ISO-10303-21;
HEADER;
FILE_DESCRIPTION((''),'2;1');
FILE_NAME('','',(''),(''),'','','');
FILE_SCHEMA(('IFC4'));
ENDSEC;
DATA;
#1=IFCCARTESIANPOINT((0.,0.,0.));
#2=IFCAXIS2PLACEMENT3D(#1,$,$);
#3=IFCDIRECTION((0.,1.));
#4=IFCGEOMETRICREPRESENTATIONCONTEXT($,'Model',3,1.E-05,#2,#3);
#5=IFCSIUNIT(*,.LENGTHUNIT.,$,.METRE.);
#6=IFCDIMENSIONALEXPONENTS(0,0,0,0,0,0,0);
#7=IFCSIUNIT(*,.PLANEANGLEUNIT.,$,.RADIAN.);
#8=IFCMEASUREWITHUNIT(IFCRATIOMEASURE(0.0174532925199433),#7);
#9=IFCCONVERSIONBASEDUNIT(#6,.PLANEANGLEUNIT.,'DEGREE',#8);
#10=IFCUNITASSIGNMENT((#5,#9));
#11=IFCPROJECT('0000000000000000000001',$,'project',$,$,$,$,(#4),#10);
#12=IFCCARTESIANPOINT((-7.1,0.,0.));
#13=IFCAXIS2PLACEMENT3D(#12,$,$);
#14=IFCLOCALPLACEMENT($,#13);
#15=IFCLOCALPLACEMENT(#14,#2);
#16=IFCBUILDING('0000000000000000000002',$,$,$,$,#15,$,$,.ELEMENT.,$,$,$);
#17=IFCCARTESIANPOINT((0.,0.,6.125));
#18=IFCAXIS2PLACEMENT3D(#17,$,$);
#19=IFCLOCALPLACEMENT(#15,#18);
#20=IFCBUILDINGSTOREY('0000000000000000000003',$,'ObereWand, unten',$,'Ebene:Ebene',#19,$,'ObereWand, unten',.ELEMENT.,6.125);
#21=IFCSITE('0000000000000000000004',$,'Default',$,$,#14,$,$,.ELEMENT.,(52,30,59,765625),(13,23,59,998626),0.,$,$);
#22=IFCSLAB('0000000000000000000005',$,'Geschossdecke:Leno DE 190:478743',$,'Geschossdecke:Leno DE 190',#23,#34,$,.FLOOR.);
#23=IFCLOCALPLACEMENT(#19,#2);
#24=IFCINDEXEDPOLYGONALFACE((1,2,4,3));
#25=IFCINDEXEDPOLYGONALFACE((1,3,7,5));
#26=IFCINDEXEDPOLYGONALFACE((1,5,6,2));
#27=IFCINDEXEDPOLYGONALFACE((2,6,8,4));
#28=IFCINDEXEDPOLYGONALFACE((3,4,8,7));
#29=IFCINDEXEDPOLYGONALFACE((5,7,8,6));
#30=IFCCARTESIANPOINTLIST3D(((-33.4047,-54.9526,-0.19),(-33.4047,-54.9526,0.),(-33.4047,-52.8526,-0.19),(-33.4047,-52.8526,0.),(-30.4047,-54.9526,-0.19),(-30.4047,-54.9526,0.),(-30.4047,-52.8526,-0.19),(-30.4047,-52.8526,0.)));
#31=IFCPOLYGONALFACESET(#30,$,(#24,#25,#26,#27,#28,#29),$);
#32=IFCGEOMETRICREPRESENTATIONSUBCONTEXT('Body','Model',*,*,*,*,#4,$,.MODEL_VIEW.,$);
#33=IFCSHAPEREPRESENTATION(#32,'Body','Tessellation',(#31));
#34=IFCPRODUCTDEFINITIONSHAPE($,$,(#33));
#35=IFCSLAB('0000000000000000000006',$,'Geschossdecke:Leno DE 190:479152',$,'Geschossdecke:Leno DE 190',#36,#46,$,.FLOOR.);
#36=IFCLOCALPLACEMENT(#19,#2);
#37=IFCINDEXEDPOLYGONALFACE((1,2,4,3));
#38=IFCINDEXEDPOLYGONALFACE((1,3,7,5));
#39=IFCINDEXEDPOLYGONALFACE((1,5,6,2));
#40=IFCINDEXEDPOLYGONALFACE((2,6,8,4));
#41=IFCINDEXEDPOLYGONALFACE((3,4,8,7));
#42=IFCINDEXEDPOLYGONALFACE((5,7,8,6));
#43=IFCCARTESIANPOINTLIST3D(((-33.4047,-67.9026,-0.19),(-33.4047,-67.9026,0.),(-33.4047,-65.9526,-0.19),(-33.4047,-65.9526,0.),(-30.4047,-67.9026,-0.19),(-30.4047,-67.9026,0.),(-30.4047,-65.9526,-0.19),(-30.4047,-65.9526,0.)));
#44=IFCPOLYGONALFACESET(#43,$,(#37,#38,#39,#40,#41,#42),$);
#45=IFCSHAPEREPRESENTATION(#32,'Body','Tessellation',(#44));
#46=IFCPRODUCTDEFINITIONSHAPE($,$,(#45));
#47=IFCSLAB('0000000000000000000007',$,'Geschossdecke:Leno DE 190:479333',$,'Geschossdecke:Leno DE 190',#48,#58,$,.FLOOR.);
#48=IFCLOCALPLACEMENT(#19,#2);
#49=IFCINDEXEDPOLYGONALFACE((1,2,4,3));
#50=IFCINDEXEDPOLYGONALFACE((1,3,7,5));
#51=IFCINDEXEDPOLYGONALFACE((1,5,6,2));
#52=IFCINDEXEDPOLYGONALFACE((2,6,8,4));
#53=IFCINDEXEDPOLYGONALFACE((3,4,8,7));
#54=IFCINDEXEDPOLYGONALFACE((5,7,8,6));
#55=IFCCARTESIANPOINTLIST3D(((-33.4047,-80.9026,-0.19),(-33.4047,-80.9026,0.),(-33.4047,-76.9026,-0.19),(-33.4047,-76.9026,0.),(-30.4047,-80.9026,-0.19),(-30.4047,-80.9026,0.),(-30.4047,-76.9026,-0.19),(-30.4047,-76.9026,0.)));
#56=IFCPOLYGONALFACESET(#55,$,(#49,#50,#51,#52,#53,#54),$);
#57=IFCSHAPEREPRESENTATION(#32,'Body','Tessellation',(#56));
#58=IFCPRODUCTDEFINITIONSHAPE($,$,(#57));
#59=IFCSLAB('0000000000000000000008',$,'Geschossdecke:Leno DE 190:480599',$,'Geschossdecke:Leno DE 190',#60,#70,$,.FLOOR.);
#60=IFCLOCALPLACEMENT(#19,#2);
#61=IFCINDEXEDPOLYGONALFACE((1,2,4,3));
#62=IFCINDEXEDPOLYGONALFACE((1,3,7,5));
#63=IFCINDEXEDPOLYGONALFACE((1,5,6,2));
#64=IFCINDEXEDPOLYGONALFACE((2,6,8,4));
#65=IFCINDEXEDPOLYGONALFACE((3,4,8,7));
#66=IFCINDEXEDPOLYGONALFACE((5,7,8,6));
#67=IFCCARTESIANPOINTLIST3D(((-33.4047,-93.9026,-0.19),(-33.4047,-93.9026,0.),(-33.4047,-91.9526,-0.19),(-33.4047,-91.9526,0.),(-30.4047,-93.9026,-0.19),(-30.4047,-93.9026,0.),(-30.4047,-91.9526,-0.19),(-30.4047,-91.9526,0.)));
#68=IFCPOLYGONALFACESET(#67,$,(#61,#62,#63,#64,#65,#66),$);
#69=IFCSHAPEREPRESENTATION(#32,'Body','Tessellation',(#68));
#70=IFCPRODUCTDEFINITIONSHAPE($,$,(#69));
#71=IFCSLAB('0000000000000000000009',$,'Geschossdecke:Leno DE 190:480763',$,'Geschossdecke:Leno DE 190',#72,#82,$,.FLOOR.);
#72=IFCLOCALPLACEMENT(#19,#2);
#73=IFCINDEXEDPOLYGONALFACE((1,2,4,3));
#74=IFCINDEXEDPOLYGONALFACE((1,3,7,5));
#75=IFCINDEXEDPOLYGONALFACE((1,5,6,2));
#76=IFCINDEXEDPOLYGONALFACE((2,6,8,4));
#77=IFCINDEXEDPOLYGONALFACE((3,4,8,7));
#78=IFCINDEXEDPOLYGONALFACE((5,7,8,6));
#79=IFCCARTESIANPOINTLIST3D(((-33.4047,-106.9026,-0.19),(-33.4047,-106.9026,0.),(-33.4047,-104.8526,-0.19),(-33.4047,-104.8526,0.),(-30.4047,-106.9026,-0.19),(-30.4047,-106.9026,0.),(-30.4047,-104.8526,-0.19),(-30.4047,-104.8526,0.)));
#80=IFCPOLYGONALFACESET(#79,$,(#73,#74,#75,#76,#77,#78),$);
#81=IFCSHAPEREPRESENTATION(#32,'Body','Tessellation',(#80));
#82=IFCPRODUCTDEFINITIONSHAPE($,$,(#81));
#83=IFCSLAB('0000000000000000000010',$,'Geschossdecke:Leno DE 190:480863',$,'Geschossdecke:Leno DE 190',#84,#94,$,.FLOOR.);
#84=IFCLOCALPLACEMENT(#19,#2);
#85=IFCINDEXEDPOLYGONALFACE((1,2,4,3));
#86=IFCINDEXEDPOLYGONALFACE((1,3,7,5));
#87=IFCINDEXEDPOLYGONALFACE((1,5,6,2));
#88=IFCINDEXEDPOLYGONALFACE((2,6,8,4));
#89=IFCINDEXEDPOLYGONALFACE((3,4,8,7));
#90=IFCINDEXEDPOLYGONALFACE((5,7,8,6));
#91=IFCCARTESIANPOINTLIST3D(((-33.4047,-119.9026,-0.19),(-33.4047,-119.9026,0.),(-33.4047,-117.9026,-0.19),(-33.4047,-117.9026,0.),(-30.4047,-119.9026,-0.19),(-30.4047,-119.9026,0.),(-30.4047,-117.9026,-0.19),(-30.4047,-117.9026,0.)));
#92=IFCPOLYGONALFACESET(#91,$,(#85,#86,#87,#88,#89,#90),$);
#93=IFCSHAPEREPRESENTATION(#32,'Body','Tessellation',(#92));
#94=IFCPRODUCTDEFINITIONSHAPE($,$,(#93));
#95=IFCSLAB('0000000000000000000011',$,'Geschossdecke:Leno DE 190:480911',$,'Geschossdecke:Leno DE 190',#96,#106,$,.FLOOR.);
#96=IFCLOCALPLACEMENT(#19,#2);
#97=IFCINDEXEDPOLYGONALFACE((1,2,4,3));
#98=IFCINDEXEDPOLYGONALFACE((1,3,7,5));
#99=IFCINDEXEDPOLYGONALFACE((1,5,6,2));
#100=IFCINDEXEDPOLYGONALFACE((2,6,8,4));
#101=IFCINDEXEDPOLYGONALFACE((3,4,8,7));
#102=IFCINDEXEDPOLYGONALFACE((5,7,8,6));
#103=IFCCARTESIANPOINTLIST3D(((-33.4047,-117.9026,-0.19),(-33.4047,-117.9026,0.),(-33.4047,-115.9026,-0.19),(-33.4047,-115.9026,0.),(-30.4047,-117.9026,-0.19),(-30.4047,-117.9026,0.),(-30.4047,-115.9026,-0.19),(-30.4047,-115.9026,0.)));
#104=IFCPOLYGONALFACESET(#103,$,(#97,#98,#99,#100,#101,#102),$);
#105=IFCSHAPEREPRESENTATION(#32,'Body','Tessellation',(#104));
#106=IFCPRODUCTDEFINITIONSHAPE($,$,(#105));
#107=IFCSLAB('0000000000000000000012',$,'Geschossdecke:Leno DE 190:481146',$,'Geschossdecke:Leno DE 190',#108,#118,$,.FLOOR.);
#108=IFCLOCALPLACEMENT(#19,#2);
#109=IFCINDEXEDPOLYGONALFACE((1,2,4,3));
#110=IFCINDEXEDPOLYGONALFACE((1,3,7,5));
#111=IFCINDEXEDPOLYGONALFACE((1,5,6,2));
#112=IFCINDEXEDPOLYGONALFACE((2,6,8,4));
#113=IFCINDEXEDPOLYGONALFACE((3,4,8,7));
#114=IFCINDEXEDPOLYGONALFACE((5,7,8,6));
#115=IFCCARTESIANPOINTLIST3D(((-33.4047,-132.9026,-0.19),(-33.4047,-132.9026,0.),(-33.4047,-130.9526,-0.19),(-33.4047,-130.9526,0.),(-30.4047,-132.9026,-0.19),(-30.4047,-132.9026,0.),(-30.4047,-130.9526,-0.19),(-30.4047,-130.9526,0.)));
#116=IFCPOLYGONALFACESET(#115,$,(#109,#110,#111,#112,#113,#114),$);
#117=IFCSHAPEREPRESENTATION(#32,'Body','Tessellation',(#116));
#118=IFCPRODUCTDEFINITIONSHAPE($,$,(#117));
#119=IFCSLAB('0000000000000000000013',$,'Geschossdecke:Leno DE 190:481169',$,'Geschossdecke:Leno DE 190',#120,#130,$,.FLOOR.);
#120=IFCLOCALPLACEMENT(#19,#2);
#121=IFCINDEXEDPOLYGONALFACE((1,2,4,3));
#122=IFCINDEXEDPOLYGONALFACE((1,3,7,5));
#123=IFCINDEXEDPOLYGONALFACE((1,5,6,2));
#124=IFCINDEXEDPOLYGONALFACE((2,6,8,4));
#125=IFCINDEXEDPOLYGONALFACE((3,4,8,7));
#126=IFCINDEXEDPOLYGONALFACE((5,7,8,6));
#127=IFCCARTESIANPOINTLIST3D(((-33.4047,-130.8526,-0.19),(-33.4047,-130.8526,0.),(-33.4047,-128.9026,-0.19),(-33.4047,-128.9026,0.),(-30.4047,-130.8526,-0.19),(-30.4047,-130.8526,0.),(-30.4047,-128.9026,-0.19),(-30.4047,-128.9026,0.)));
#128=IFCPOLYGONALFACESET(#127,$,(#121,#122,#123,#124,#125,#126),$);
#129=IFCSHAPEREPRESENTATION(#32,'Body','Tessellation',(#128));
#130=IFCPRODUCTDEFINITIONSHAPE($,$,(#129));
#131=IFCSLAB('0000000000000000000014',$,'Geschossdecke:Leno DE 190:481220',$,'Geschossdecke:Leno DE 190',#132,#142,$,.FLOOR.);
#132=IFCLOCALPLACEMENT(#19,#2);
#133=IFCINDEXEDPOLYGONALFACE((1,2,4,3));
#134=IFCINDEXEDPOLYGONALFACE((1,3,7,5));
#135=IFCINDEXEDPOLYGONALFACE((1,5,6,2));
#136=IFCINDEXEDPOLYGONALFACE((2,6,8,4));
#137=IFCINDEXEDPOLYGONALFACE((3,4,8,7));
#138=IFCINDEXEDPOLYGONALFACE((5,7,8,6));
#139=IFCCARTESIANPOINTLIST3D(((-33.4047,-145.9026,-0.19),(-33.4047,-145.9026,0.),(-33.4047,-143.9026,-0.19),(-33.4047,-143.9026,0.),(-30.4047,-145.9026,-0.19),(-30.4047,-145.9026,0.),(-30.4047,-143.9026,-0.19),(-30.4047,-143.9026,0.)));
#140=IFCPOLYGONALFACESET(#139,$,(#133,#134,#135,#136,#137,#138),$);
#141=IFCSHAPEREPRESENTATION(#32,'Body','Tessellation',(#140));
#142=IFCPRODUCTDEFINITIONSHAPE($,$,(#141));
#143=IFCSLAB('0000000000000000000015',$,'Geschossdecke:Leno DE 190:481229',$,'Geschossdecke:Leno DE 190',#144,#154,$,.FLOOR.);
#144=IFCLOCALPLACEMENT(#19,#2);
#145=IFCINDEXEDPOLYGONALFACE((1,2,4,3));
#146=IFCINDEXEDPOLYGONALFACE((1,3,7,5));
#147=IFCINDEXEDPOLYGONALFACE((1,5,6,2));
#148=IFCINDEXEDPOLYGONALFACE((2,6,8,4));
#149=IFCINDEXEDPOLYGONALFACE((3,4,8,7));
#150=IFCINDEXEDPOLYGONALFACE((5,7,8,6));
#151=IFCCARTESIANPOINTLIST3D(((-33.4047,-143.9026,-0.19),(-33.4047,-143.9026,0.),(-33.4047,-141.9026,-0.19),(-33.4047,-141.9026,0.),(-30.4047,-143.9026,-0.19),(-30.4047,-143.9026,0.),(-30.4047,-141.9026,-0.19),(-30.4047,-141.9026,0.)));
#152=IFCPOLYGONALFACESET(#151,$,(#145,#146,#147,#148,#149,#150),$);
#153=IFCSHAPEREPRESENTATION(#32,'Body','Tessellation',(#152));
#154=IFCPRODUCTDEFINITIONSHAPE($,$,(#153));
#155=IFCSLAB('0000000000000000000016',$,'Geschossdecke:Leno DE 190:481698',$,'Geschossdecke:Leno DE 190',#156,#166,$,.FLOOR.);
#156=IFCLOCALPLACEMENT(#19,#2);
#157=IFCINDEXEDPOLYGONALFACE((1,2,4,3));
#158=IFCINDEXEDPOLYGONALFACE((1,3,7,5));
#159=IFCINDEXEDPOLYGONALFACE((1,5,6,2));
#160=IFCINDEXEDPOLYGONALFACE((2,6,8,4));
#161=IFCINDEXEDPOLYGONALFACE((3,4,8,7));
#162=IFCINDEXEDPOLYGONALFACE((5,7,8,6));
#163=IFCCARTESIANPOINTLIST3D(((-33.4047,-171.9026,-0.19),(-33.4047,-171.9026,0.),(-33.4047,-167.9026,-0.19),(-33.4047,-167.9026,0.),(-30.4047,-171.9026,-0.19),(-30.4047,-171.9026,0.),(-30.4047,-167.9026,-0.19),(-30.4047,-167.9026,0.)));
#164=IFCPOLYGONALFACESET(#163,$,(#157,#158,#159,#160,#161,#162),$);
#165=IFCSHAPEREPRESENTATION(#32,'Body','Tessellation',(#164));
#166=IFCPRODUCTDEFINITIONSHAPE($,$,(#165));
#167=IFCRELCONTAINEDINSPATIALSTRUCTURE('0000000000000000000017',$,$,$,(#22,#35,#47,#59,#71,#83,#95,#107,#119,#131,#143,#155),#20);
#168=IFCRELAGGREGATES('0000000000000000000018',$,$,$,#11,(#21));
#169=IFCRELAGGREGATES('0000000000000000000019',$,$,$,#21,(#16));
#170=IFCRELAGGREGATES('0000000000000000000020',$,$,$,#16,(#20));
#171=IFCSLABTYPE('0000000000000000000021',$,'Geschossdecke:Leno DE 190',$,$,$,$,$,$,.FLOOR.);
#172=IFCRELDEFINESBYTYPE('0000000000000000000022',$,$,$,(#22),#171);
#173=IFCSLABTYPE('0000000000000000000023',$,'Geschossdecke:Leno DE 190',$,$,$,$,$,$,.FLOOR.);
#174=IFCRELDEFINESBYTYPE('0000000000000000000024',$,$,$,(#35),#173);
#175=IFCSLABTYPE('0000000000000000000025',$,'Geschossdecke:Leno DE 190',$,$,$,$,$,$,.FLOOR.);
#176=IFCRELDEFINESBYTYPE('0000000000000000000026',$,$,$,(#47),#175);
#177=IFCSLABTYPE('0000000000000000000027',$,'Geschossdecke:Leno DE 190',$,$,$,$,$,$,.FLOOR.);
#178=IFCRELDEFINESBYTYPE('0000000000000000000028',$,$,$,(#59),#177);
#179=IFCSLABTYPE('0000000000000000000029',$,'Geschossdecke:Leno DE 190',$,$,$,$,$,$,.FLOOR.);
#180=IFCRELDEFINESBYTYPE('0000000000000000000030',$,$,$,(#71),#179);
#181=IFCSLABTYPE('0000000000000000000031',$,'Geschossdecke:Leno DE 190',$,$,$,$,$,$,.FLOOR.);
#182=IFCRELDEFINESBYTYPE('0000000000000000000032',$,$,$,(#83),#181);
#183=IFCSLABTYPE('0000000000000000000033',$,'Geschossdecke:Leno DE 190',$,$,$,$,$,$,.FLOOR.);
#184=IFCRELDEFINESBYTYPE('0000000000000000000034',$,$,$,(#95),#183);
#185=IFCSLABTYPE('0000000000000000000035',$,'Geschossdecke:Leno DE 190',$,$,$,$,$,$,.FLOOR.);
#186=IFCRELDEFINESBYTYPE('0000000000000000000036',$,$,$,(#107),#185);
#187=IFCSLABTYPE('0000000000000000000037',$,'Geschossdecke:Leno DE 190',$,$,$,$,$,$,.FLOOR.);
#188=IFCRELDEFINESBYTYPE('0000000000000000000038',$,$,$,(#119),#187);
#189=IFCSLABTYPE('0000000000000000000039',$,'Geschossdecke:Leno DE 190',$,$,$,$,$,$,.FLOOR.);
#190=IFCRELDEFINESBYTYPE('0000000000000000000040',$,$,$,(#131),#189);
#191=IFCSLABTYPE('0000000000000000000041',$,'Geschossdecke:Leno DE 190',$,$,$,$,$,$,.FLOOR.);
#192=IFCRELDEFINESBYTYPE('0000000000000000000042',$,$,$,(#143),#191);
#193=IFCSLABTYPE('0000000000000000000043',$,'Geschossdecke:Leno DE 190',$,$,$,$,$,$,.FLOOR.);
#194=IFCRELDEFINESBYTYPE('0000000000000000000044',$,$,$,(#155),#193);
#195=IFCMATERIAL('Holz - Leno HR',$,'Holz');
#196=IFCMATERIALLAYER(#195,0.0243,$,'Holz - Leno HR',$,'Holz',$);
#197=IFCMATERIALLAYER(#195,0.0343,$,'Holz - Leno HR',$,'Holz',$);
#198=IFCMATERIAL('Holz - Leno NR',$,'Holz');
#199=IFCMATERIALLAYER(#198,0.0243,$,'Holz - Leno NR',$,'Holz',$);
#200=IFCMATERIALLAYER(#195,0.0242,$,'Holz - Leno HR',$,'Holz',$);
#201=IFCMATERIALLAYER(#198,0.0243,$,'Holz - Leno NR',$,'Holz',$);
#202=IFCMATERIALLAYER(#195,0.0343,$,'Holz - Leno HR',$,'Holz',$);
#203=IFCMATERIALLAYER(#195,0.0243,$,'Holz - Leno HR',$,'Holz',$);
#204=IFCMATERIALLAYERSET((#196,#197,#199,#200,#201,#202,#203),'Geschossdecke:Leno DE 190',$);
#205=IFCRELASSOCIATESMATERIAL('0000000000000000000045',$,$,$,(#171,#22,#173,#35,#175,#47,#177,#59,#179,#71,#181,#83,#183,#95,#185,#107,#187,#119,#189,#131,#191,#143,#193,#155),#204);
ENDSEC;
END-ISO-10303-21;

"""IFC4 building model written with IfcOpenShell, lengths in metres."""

from ifc_helpers import new_model, entity, si_unit, converted_unit, direction, frame, origin, place, context, subcontext, project, spatial, indexed_curve, outline, extrude, material, layer, layer_set, type_object, element, save


model = new_model("IFC4")

# Units and contexts
model_context = context("Model", 3, precision=1e-05, world=origin(), true_north=direction((0.0, 1.0)))
body_context = subcontext(model_context, "Body", "Model", "MODEL_VIEW")
ifc_project = project(units=[si_unit("LENGTHUNIT", "METRE"), converted_unit("PLANEANGLEUNIT", "DEGREE", entity("IfcRatioMeasure", 0.0174532925199433), si_unit("PLANEANGLEUNIT", "RADIAN"), dimensions=[0, 0, 0, 0, 0, 0, 0])], contexts=[model_context])

# Site, building, storey
site_placement = place(None, frame((-7.1, 0.0, 0.0)))
site = spatial("IfcSite", under=ifc_project, at=site_placement, Name="Default", CompositionType="ELEMENT", RefLatitude=(52, 30, 59, 765625), RefLongitude=(13, 23, 59, 998626), RefElevation=0.0)
building_placement = place(site_placement, origin())
building = spatial("IfcBuilding", under=site, at=building_placement, CompositionType="ELEMENT")
storey_placement = place(building_placement, frame((0.0, 0.0, 6.125)))
storey = spatial("IfcBuildingStorey", under=building, at=storey_placement, Name="ObereWand, unten", ObjectType="Ebene:Ebene", LongName="ObereWand, unten", CompositionType="ELEMENT", Elevation=6.125)

# Slabs
ifc_material_1 = material(Name="Holz - Leno HR", Category="Holz")
ifc_layer_1 = layer(ifc_material_1, 0.0243, Name="Holz - Leno HR", Category="Holz")
ifc_layer_2 = layer(ifc_material_1, 0.0343, Name="Holz - Leno HR", Category="Holz")
ifc_material_2 = material(Name="Holz - Leno NR", Category="Holz")
ifc_layer_3 = layer(ifc_material_2, 0.0243, Name="Holz - Leno NR", Category="Holz")
ifc_layer_4 = layer(ifc_material_1, 0.0242, Name="Holz - Leno HR", Category="Holz")
ifc_layer_5 = layer(ifc_material_2, 0.0243, Name="Holz - Leno NR", Category="Holz")
ifc_layer_6 = layer(ifc_material_1, 0.0343, Name="Holz - Leno HR", Category="Holz")
ifc_layer_7 = layer(ifc_material_1, 0.0243, Name="Holz - Leno HR", Category="Holz")
ifc_layer_set_1 = layer_set([ifc_layer_1, ifc_layer_2, ifc_layer_3, ifc_layer_4, ifc_layer_5, ifc_layer_6, ifc_layer_7], Name="Geschossdecke:Leno DE 190")
slab_type_1 = type_object("IfcSlabType", Name="Geschossdecke:Leno DE 190", PredefinedType="FLOOR", material=ifc_layer_set_1)
slab_1_placement = place(storey_placement, origin())
element("IfcSlab", 1, at=slab_1_placement, inside=storey, type_object=slab_type_1, material=ifc_layer_set_1, Name="Geschossdecke:Leno DE 190:478743", ObjectType="Geschossdecke:Leno DE 190", PredefinedType="FLOOR", context=body_context, shape_type="SweptSolid", body=[
    extrude(outline(indexed_curve([(-1.05, -1.5), (1.05, -1.5), (1.05, 1.5), (-1.05, 1.5), (-1.05, -1.5)], self_intersect=False)), frame((-31.9047, -53.9026, 0.0), z_axis=(0.0, 0.0, -1.0), x_axis=(0.0, 1.0, 0.0)), (0.0, 0.0, 1.0), 0.19),
])
slab_type_2 = type_object("IfcSlabType", Name="Geschossdecke:Leno DE 190", PredefinedType="FLOOR", material=ifc_layer_set_1)
slab_2_placement = place(storey_placement, origin())
element("IfcSlab", 2, at=slab_2_placement, inside=storey, type_object=slab_type_2, material=ifc_layer_set_1, Name="Geschossdecke:Leno DE 190:479152", ObjectType="Geschossdecke:Leno DE 190", PredefinedType="FLOOR", context=body_context, shape_type="SweptSolid", body=[
    extrude(outline(indexed_curve([(-0.975, -1.5), (0.975, -1.5), (0.975, 1.5), (-0.975, 1.5), (-0.975, -1.5)], self_intersect=False)), frame((-31.9047, -66.9276, 0.0), z_axis=(0.0, 0.0, -1.0), x_axis=(0.0, 1.0, 0.0)), (0.0, 0.0, 1.0), 0.19),
])
slab_type_3 = type_object("IfcSlabType", Name="Geschossdecke:Leno DE 190", PredefinedType="FLOOR", material=ifc_layer_set_1)
slab_3_placement = place(storey_placement, origin())
element("IfcSlab", 3, at=slab_3_placement, inside=storey, type_object=slab_type_3, material=ifc_layer_set_1, Name="Geschossdecke:Leno DE 190:479333", ObjectType="Geschossdecke:Leno DE 190", PredefinedType="FLOOR", context=body_context, shape_type="SweptSolid", body=[
    extrude(outline(indexed_curve([(-2.0, -1.5), (2.0, -1.5), (2.0, 1.5), (-2.0, 1.5), (-2.0, -1.5)], self_intersect=False)), frame((-31.9047, -78.9026, 0.0), z_axis=(0.0, 0.0, -1.0), x_axis=(0.0, 1.0, 0.0)), (0.0, 0.0, 1.0), 0.19),
])
slab_type_4 = type_object("IfcSlabType", Name="Geschossdecke:Leno DE 190", PredefinedType="FLOOR", material=ifc_layer_set_1)
slab_4_placement = place(storey_placement, origin())
element("IfcSlab", 4, at=slab_4_placement, inside=storey, type_object=slab_type_4, material=ifc_layer_set_1, Name="Geschossdecke:Leno DE 190:480599", ObjectType="Geschossdecke:Leno DE 190", PredefinedType="FLOOR", context=body_context, shape_type="SweptSolid", body=[
    extrude(outline(indexed_curve([(-0.975, -1.5), (0.975, -1.5), (0.975, 1.5), (-0.975, 1.5), (-0.975, -1.5)], self_intersect=False)), frame((-31.9047, -92.9276, 0.0), z_axis=(0.0, 0.0, -1.0), x_axis=(0.0, 1.0, 0.0)), (0.0, 0.0, 1.0), 0.19),
])
slab_type_5 = type_object("IfcSlabType", Name="Geschossdecke:Leno DE 190", PredefinedType="FLOOR", material=ifc_layer_set_1)
slab_5_placement = place(storey_placement, origin())
element("IfcSlab", 5, at=slab_5_placement, inside=storey, type_object=slab_type_5, material=ifc_layer_set_1, Name="Geschossdecke:Leno DE 190:480763", ObjectType="Geschossdecke:Leno DE 190", PredefinedType="FLOOR", context=body_context, shape_type="SweptSolid", body=[
    extrude(outline(indexed_curve([(-1.025, -1.5), (1.025, -1.5), (1.025, 1.5), (-1.025, 1.5), (-1.025, -1.5)], self_intersect=False)), frame((-31.9047, -105.8776, 0.0), z_axis=(0.0, 0.0, -1.0), x_axis=(0.0, 1.0, 0.0)), (0.0, 0.0, 1.0), 0.19),
])
slab_type_6 = type_object("IfcSlabType", Name="Geschossdecke:Leno DE 190", PredefinedType="FLOOR", material=ifc_layer_set_1)
slab_6_placement = place(storey_placement, origin())
element("IfcSlab", 6, at=slab_6_placement, inside=storey, type_object=slab_type_6, material=ifc_layer_set_1, Name="Geschossdecke:Leno DE 190:480863", ObjectType="Geschossdecke:Leno DE 190", PredefinedType="FLOOR", context=body_context, shape_type="SweptSolid", body=[
    extrude(outline(indexed_curve([(-1.0, -1.5), (1.0, -1.5), (1.0, 1.5), (-1.0, 1.5), (-1.0, -1.5)], self_intersect=False)), frame((-31.9047, -118.9026, 0.0), z_axis=(0.0, 0.0, -1.0), x_axis=(0.0, 1.0, 0.0)), (0.0, 0.0, 1.0), 0.19),
])
slab_type_7 = type_object("IfcSlabType", Name="Geschossdecke:Leno DE 190", PredefinedType="FLOOR", material=ifc_layer_set_1)
slab_7_placement = place(storey_placement, origin())
element("IfcSlab", 7, at=slab_7_placement, inside=storey, type_object=slab_type_7, material=ifc_layer_set_1, Name="Geschossdecke:Leno DE 190:480911", ObjectType="Geschossdecke:Leno DE 190", PredefinedType="FLOOR", context=body_context, shape_type="SweptSolid", body=[
    extrude(outline(indexed_curve([(-1.0, -1.5), (1.0, -1.5), (1.0, 1.5), (-1.0, 1.5), (-1.0, -1.5)], self_intersect=False)), frame((-31.9047, -116.9026, 0.0), z_axis=(0.0, 0.0, -1.0), x_axis=(0.0, 1.0, 0.0)), (0.0, 0.0, 1.0), 0.19),
])
slab_type_8 = type_object("IfcSlabType", Name="Geschossdecke:Leno DE 190", PredefinedType="FLOOR", material=ifc_layer_set_1)
slab_8_placement = place(storey_placement, origin())
element("IfcSlab", 8, at=slab_8_placement, inside=storey, type_object=slab_type_8, material=ifc_layer_set_1, Name="Geschossdecke:Leno DE 190:481146", ObjectType="Geschossdecke:Leno DE 190", PredefinedType="FLOOR", context=body_context, shape_type="SweptSolid", body=[
    extrude(outline(indexed_curve([(-0.975, -1.5), (0.975, -1.5), (0.975, 1.5), (-0.975, 1.5), (-0.975, -1.5)], self_intersect=False)), frame((-31.9047, -131.9276, 0.0), z_axis=(0.0, 0.0, -1.0), x_axis=(0.0, 1.0, 0.0)), (0.0, 0.0, 1.0), 0.19),
])
slab_type_9 = type_object("IfcSlabType", Name="Geschossdecke:Leno DE 190", PredefinedType="FLOOR", material=ifc_layer_set_1)
slab_9_placement = place(storey_placement, origin())
element("IfcSlab", 9, at=slab_9_placement, inside=storey, type_object=slab_type_9, material=ifc_layer_set_1, Name="Geschossdecke:Leno DE 190:481169", ObjectType="Geschossdecke:Leno DE 190", PredefinedType="FLOOR", context=body_context, shape_type="SweptSolid", body=[
    extrude(outline(indexed_curve([(-0.975, -1.5), (0.975, -1.5), (0.975, 1.5), (-0.975, 1.5), (-0.975, -1.5)], self_intersect=False)), frame((-31.9047, -129.8776, 0.0), z_axis=(0.0, 0.0, -1.0), x_axis=(0.0, 1.0, 0.0)), (0.0, 0.0, 1.0), 0.19),
])
slab_type_10 = type_object("IfcSlabType", Name="Geschossdecke:Leno DE 190", PredefinedType="FLOOR", material=ifc_layer_set_1)
slab_10_placement = place(storey_placement, origin())
element("IfcSlab", 10, at=slab_10_placement, inside=storey, type_object=slab_type_10, material=ifc_layer_set_1, Name="Geschossdecke:Leno DE 190:481220", ObjectType="Geschossdecke:Leno DE 190", PredefinedType="FLOOR", context=body_context, shape_type="SweptSolid", body=[
    extrude(outline(indexed_curve([(-1.0, -1.5), (1.0, -1.5), (1.0, 1.5), (-1.0, 1.5), (-1.0, -1.5)], self_intersect=False)), frame((-31.9047, -144.9026, 0.0), z_axis=(0.0, 0.0, -1.0), x_axis=(0.0, 1.0, 0.0)), (0.0, 0.0, 1.0), 0.19),
])
slab_type_11 = type_object("IfcSlabType", Name="Geschossdecke:Leno DE 190", PredefinedType="FLOOR", material=ifc_layer_set_1)
slab_11_placement = place(storey_placement, origin())
element("IfcSlab", 11, at=slab_11_placement, inside=storey, type_object=slab_type_11, material=ifc_layer_set_1, Name="Geschossdecke:Leno DE 190:481229", ObjectType="Geschossdecke:Leno DE 190", PredefinedType="FLOOR", context=body_context, shape_type="SweptSolid", body=[
    extrude(outline(indexed_curve([(-1.0, -1.5), (1.0, -1.5), (1.0, 1.5), (-1.0, 1.5), (-1.0, -1.5)], self_intersect=False)), frame((-31.9047, -142.9026, 0.0), z_axis=(0.0, 0.0, -1.0), x_axis=(0.0, 1.0, 0.0)), (0.0, 0.0, 1.0), 0.19),
])
slab_type_12 = type_object("IfcSlabType", Name="Geschossdecke:Leno DE 190", PredefinedType="FLOOR", material=ifc_layer_set_1)
slab_12_placement = place(storey_placement, origin())
element("IfcSlab", 12, at=slab_12_placement, inside=storey, type_object=slab_type_12, material=ifc_layer_set_1, Name="Geschossdecke:Leno DE 190:481698", ObjectType="Geschossdecke:Leno DE 190", PredefinedType="FLOOR", context=body_context, shape_type="SweptSolid", body=[
    extrude(outline(indexed_curve([(-2.0, -1.5), (2.0, -1.5), (2.0, 1.5), (-2.0, 1.5), (-2.0, -1.5)], self_intersect=False)), frame((-31.9047, -169.9026, 0.0), z_axis=(0.0, 0.0, -1.0), x_axis=(0.0, 1.0, 0.0)), (0.0, 0.0, 1.0), 0.19),
])

save(model, "model.ifc")
